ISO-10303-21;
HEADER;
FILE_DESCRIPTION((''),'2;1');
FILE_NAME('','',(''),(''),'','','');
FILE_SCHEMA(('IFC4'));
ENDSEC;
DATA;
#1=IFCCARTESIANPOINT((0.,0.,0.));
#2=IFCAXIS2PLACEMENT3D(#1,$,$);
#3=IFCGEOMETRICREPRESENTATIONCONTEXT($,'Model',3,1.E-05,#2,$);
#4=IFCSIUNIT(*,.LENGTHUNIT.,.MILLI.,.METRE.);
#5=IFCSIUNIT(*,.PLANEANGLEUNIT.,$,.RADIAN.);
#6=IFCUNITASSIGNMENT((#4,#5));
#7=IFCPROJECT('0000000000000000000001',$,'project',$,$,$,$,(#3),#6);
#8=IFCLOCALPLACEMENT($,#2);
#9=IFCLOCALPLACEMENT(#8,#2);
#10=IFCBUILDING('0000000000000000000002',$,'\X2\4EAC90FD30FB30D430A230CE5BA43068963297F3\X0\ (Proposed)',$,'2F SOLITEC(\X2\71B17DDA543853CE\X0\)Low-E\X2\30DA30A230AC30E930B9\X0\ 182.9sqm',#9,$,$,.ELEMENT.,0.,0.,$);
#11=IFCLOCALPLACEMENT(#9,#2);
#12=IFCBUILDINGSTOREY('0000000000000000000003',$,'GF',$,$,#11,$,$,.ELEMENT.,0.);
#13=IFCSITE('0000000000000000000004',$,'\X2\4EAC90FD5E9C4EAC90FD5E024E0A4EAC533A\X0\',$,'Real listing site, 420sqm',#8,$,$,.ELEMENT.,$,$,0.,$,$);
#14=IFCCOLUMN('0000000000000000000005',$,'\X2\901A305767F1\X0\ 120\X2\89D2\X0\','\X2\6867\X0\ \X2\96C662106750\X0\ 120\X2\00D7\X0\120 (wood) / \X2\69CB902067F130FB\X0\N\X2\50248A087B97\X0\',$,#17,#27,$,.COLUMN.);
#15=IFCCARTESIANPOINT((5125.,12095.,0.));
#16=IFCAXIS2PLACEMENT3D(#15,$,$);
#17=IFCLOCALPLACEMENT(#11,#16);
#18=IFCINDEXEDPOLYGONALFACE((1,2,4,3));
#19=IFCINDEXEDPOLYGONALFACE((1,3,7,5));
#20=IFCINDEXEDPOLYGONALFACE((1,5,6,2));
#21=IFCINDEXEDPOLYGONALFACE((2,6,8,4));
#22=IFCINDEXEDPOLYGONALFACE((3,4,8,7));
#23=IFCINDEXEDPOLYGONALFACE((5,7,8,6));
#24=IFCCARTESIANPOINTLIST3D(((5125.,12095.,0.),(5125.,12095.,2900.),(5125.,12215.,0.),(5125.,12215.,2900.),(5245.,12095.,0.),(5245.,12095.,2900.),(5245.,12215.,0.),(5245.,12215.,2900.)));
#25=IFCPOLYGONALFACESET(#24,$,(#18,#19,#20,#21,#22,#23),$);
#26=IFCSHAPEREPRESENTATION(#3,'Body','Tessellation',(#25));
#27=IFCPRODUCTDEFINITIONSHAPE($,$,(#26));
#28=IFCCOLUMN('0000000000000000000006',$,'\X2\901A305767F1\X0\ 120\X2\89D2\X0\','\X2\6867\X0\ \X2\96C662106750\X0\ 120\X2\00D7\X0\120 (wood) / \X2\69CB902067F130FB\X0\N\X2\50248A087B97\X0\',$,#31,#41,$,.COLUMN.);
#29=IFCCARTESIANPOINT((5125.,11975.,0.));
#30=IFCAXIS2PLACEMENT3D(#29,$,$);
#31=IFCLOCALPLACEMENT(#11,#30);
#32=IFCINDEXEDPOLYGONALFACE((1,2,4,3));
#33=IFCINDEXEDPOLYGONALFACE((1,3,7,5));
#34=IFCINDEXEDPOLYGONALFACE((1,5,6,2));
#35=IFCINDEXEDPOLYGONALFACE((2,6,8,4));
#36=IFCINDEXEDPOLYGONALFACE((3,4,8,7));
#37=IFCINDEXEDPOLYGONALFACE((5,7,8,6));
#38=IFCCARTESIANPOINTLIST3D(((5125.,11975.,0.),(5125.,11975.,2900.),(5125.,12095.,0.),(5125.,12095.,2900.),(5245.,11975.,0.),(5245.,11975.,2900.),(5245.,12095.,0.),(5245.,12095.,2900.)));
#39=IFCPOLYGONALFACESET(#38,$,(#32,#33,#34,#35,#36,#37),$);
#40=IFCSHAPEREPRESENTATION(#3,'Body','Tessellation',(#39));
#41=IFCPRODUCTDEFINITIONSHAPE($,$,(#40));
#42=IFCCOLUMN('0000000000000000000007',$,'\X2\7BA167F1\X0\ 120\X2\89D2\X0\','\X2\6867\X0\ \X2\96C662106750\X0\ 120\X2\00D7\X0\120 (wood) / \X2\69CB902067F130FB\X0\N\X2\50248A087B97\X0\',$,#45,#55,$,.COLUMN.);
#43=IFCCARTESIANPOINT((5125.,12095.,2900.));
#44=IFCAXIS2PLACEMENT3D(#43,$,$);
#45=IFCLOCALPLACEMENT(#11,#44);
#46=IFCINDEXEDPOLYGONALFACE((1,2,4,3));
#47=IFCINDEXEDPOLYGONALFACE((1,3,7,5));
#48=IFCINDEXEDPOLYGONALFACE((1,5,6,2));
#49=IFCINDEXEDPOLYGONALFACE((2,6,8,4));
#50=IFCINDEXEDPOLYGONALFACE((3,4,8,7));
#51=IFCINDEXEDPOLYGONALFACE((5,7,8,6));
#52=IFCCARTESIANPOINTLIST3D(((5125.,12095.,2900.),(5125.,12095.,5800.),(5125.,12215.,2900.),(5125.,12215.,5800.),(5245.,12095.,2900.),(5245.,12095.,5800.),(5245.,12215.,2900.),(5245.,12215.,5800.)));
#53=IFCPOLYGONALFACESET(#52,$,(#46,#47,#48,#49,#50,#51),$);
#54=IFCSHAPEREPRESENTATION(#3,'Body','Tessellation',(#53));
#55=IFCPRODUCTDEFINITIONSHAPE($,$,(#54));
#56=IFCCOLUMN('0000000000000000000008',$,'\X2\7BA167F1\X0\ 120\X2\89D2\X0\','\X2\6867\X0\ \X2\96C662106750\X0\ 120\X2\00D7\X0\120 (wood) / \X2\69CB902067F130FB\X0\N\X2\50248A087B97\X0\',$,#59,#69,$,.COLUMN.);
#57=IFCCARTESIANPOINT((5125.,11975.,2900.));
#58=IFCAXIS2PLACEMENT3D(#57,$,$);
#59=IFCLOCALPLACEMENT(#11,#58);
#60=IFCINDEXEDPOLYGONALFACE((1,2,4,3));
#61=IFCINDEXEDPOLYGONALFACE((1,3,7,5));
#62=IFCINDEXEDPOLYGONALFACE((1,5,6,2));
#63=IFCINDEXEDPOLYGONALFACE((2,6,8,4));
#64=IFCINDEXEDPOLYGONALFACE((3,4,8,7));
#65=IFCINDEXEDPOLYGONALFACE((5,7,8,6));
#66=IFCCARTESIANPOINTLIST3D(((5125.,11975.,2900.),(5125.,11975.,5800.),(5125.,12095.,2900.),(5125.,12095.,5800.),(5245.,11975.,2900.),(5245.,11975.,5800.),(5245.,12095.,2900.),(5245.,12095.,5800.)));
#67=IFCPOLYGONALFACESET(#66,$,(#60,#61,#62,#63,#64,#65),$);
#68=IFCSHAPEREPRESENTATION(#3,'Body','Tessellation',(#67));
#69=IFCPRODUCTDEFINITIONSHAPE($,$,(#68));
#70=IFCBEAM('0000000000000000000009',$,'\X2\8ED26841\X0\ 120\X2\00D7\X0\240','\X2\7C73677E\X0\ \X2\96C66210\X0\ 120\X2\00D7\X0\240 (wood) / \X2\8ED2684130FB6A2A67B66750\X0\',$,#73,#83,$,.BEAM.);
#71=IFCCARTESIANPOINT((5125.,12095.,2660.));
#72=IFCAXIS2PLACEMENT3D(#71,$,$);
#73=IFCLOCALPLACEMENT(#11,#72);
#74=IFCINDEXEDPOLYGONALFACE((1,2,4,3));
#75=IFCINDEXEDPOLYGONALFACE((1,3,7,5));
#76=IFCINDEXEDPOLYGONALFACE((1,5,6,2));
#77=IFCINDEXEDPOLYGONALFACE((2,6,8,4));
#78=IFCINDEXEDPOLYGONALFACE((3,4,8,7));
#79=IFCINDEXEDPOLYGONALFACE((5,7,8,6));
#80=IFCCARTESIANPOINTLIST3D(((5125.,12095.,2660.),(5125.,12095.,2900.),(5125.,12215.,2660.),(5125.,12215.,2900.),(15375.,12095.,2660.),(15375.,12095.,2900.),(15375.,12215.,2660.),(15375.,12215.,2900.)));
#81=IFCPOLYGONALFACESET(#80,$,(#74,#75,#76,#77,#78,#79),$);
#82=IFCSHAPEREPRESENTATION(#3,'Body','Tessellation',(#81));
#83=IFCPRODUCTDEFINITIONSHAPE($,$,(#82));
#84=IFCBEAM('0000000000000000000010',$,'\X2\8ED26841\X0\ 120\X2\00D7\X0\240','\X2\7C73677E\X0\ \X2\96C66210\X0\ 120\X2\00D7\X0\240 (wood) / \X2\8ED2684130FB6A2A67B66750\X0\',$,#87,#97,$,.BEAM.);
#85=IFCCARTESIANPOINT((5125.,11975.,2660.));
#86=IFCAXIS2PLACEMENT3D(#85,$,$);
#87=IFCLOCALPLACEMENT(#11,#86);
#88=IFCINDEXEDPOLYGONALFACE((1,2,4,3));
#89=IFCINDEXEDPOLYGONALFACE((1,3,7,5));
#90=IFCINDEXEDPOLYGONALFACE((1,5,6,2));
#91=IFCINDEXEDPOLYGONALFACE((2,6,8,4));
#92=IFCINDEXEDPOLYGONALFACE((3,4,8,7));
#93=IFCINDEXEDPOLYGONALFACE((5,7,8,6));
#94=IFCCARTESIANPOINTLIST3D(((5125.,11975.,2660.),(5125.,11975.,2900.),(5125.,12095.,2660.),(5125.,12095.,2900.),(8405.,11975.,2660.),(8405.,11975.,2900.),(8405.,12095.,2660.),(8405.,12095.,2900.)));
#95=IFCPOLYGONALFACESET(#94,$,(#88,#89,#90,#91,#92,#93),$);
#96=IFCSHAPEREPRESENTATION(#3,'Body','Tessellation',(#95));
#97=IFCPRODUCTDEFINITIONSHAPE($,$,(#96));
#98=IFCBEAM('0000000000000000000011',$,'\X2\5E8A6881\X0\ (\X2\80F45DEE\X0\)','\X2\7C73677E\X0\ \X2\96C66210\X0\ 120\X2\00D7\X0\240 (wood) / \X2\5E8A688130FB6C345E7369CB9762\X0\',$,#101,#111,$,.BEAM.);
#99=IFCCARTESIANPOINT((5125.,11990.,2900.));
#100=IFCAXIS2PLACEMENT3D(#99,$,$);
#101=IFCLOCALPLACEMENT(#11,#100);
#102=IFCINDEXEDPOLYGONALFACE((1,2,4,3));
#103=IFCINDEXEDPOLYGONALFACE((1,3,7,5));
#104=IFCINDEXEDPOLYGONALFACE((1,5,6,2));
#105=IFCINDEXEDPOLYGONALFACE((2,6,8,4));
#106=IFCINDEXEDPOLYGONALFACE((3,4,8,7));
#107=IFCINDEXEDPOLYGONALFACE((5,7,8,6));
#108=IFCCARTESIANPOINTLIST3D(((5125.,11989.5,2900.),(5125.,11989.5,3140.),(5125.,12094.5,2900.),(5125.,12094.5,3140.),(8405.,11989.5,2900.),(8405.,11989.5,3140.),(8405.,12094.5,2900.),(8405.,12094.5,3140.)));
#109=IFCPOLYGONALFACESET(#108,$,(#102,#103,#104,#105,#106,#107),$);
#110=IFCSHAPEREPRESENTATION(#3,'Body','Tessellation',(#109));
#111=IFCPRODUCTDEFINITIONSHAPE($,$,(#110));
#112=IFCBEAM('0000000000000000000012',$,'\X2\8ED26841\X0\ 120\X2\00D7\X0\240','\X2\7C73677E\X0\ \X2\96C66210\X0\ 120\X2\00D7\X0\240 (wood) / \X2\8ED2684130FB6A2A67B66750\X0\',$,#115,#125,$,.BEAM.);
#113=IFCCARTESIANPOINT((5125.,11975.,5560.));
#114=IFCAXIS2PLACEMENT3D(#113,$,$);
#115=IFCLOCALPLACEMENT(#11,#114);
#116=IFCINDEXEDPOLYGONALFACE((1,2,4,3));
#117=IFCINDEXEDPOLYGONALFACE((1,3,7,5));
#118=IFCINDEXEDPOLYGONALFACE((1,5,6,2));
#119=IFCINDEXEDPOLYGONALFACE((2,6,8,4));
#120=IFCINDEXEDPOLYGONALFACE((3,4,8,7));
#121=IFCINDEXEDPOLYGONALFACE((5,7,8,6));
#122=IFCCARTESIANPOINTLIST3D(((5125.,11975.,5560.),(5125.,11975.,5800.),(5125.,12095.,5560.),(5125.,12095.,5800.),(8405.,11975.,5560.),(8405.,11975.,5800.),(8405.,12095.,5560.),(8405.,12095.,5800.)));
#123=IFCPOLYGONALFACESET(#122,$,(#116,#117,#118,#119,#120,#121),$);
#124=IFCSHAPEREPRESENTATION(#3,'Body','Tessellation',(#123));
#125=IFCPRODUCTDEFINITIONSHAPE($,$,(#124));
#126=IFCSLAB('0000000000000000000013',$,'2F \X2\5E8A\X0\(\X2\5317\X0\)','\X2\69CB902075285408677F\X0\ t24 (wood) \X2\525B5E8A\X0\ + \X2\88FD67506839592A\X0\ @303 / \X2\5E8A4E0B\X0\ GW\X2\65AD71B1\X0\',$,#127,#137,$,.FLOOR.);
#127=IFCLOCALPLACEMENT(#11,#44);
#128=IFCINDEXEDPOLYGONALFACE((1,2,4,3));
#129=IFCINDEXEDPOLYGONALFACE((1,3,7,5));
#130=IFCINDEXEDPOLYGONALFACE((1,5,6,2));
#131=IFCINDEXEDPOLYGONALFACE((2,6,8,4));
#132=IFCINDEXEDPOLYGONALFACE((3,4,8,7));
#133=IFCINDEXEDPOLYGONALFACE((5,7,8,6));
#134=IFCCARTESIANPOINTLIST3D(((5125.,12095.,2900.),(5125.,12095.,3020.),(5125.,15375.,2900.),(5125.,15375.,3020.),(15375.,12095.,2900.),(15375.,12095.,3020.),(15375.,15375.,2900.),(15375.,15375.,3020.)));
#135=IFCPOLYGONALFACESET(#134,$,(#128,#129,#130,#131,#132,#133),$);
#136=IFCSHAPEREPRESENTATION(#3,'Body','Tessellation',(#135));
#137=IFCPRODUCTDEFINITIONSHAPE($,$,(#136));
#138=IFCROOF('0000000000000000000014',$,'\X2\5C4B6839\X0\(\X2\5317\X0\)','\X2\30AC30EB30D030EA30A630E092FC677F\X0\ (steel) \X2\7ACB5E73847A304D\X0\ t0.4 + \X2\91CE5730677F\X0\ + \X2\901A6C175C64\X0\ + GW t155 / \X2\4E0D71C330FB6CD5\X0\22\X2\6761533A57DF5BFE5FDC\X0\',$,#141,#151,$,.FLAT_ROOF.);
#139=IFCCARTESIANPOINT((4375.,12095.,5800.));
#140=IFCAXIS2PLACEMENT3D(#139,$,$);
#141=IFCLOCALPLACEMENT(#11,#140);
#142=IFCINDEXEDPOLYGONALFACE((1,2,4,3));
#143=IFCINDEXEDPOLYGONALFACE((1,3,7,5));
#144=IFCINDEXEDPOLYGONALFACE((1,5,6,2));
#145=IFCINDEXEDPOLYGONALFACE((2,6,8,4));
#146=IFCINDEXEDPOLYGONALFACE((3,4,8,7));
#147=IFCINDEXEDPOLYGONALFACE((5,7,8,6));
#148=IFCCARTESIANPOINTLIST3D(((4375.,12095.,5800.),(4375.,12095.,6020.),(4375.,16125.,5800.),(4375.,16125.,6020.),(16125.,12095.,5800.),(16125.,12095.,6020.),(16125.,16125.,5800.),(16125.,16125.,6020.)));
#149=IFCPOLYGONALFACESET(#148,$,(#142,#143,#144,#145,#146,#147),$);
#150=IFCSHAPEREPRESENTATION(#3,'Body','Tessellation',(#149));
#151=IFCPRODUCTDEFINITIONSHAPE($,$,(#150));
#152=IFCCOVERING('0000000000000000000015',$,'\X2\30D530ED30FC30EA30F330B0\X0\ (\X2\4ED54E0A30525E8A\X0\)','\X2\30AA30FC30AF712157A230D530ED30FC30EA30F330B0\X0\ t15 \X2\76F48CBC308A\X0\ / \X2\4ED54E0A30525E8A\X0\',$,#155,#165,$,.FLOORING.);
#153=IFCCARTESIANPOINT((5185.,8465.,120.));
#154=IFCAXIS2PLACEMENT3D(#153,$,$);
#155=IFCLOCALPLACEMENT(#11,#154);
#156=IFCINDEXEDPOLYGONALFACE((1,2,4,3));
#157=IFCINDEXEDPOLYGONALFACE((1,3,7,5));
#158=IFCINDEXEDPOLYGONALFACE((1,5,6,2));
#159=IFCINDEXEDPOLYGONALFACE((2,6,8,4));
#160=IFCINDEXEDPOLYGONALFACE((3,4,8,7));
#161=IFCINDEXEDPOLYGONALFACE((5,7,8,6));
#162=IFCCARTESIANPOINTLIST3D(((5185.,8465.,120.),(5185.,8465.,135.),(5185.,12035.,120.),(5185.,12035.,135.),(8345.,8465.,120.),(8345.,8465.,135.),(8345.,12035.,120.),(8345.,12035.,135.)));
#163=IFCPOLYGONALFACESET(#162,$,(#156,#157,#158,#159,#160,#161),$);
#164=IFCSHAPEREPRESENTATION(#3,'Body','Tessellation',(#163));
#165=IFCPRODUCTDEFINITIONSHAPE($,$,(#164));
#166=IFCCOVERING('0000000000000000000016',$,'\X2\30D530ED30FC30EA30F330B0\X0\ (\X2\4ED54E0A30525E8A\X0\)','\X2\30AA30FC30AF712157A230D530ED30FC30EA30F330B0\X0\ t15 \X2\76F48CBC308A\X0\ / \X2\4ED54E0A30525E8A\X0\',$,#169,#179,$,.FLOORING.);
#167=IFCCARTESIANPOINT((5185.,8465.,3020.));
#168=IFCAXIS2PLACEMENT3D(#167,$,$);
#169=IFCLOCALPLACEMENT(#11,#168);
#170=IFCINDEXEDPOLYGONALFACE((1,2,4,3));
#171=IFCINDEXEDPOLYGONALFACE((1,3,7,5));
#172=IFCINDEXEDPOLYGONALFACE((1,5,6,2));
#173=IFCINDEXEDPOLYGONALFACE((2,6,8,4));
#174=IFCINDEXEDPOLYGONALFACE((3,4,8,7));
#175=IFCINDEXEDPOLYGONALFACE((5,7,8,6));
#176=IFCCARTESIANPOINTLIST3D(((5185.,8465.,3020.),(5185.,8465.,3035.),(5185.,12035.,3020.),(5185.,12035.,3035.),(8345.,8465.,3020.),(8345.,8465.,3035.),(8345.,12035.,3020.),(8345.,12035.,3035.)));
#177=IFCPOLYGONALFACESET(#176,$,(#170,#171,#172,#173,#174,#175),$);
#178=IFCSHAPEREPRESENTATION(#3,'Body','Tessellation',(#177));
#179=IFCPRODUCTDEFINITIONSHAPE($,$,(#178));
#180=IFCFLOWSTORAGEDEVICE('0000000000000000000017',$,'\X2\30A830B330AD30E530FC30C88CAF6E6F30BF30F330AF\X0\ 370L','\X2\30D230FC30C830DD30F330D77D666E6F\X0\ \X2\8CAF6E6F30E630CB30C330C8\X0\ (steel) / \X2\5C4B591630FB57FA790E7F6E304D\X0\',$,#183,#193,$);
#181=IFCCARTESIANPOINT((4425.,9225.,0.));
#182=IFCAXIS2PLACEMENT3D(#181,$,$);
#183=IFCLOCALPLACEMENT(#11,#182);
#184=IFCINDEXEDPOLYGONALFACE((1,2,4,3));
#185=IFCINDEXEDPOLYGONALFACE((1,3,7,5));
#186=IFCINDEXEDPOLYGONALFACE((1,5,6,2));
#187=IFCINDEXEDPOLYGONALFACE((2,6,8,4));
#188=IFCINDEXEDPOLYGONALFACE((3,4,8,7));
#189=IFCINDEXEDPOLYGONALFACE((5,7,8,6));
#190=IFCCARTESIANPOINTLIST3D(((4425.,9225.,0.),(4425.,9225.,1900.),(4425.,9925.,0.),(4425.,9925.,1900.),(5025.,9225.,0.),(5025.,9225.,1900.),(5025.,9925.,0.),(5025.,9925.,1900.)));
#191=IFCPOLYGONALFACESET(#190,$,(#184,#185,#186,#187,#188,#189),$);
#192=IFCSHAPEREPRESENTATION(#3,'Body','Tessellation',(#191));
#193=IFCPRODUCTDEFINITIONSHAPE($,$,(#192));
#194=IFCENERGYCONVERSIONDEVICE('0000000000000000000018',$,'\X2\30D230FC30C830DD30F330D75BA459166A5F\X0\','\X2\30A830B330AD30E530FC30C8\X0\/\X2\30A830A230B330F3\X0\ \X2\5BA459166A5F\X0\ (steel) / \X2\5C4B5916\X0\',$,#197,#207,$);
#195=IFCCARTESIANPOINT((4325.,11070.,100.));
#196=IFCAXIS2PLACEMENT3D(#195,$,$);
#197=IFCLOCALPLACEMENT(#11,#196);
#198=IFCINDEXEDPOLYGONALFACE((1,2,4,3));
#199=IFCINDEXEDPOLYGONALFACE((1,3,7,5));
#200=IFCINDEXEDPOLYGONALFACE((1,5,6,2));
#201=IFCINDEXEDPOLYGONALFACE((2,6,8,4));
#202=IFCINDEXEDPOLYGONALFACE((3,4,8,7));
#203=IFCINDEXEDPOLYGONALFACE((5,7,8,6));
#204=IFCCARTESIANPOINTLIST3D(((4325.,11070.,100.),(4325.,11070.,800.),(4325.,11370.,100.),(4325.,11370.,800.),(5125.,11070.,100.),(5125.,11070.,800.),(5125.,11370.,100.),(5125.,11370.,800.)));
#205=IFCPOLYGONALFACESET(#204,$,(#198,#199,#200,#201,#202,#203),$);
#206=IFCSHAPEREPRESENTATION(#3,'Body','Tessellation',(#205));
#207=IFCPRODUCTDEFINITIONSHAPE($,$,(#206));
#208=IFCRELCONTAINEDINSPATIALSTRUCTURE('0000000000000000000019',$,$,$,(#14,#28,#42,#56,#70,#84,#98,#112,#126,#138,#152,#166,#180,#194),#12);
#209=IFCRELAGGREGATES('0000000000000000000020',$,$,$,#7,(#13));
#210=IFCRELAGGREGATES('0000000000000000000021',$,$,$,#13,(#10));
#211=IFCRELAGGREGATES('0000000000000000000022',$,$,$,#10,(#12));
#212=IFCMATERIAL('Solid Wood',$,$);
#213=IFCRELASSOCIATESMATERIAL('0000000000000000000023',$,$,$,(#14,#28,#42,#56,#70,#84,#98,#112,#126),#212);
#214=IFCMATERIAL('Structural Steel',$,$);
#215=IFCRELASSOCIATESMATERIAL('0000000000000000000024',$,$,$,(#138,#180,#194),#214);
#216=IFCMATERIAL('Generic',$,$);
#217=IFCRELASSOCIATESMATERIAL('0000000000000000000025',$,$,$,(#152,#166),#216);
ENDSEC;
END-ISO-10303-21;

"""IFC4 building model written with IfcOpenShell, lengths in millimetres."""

from ifc_helpers import new_model, si_unit, frame, frame_2d, origin, place, context, project, spatial, rectangle, extrude, material, element, save


model = new_model("IFC4")

# Units and contexts
model_context = context("Model", 3, precision=1e-05, world=origin())
ifc_project = project(units=[si_unit("LENGTHUNIT", "METRE", prefix="MILLI"), si_unit("PLANEANGLEUNIT", "RADIAN")], contexts=[model_context])

# Site, building, storey
site_placement = place(None, origin())
site = spatial("IfcSite", under=ifc_project, at=site_placement, Name="京都府京都市上京区", ObjectType="Real listing site, 420sqm", CompositionType="ELEMENT", RefElevation=0.0)
building_placement = place(site_placement, origin())
building = spatial("IfcBuilding", under=site, at=building_placement, Name="京都・ピアノ室と防音 (Proposed)", ObjectType="2F SOLITEC(熱線吸収)Low-Eペアガラス 182.9sqm", CompositionType="ELEMENT", ElevationOfRefHeight=0.0, ElevationOfTerrain=0.0)
storey_placement = place(building_placement, origin())
storey = spatial("IfcBuildingStorey", under=building, at=storey_placement, Name="GF", CompositionType="ELEMENT", Elevation=0.0)

# Columns
ifc_material_1 = material(Name="Solid Wood")
column_1_placement = place(storey_placement, frame((5125.0, 12095.0, 0.0)))
element("IfcColumn", 1, at=column_1_placement, inside=storey, material=ifc_material_1, Name="通し柱 120角", Description="桧 集成材 120×120 (wood) / 構造柱・N値計算", PredefinedType="COLUMN", context=model_context, shape_type="SweptSolid", body=[
    extrude(rectangle(XDim=120.0, YDim=120.0, at=frame_2d((60.0, 60.0))), frame((5125.0, 12095.0, 0.0)), (0.0, 0.0, 1.0), 2900.0),
])
column_2_placement = place(storey_placement, frame((5125.0, 11975.0, 0.0)))
element("IfcColumn", 2, at=column_2_placement, inside=storey, material=ifc_material_1, Name="通し柱 120角", Description="桧 集成材 120×120 (wood) / 構造柱・N値計算", PredefinedType="COLUMN", context=model_context, shape_type="SweptSolid", body=[
    extrude(rectangle(XDim=120.0, YDim=120.0, at=frame_2d((60.0, 60.0))), frame((5125.0, 11975.0, 0.0)), (0.0, 0.0, 1.0), 2900.0),
])
column_3_placement = place(storey_placement, frame((5125.0, 12095.0, 2900.0)))
element("IfcColumn", 3, at=column_3_placement, inside=storey, material=ifc_material_1, Name="管柱 120角", Description="桧 集成材 120×120 (wood) / 構造柱・N値計算", PredefinedType="COLUMN", context=model_context, shape_type="SweptSolid", body=[
    extrude(rectangle(XDim=120.0, YDim=120.0, at=frame_2d((60.0, 60.0))), frame((5125.0, 12095.0, 2900.0)), (0.0, 0.0, 1.0), 2900.0),
])
column_4_placement = place(storey_placement, frame((5125.0, 11975.0, 2900.0)))
element("IfcColumn", 4, at=column_4_placement, inside=storey, material=ifc_material_1, Name="管柱 120角", Description="桧 集成材 120×120 (wood) / 構造柱・N値計算", PredefinedType="COLUMN", context=model_context, shape_type="SweptSolid", body=[
    extrude(rectangle(XDim=120.0, YDim=120.0, at=frame_2d((60.0, 60.0))), frame((5125.0, 11975.0, 2900.0)), (0.0, 0.0, 1.0), 2900.0),
])

# Beams
beam_1_placement = place(storey_placement, frame((5125.0, 12095.0, 2660.0)))
element("IfcBeam", 5, at=beam_1_placement, inside=storey, material=ifc_material_1, Name="軒桁 120×240", Description="米松 集成 120×240 (wood) / 軒桁・横架材", PredefinedType="BEAM", context=model_context, shape_type="SweptSolid", body=[
    extrude(rectangle(XDim=10250.0, YDim=120.0, at=frame_2d((5125.0, 60.0))), frame((5125.0, 12095.0, 2660.0)), (0.0, 0.0, 1.0), 240.0),
])
beam_2_placement = place(storey_placement, frame((5125.0, 11975.0, 2660.0)))
element("IfcBeam", 6, at=beam_2_placement, inside=storey, material=ifc_material_1, Name="軒桁 120×240", Description="米松 集成 120×240 (wood) / 軒桁・横架材", PredefinedType="BEAM", context=model_context, shape_type="SweptSolid", body=[
    extrude(rectangle(XDim=3280.0, YDim=120.0, at=frame_2d((1640.0, 60.0))), frame((5125.0, 11975.0, 2660.0)), (0.0, 0.0, 1.0), 240.0),
])
beam_3_placement = place(storey_placement, frame((5125.0, 11990.0, 2900.0)))
element("IfcBeam", 7, at=beam_3_placement, inside=storey, material=ifc_material_1, Name="床梁 (胴差)", Description="米松 集成 120×240 (wood) / 床梁・水平構面", PredefinedType="BEAM", context=model_context, shape_type="SweptSolid", body=[
    extrude(rectangle(XDim=3280.0, YDim=105.0, at=frame_2d((1640.0, 52.0))), frame((5125.0, 11990.0, 2900.0)), (0.0, 0.0, 1.0), 240.0),
])
beam_4_placement = place(storey_placement, frame((5125.0, 11975.0, 5560.0)))
element("IfcBeam", 8, at=beam_4_placement, inside=storey, material=ifc_material_1, Name="軒桁 120×240", Description="米松 集成 120×240 (wood) / 軒桁・横架材", PredefinedType="BEAM", context=model_context, shape_type="SweptSolid", body=[
    extrude(rectangle(XDim=3280.0, YDim=120.0, at=frame_2d((1640.0, 60.0))), frame((5125.0, 11975.0, 5560.0)), (0.0, 0.0, 1.0), 240.0),
])

# Slab
slab_1_placement = place(storey_placement, frame((5125.0, 12095.0, 2900.0)))
element("IfcSlab", 9, at=slab_1_placement, inside=storey, material=ifc_material_1, Name="2F 床(北)", Description="構造用合板 t24 (wood) 剛床 + 製材根太 @303 / 床下 GW断熱", PredefinedType="FLOOR", context=model_context, shape_type="SweptSolid", body=[
    extrude(rectangle(XDim=10250.0, YDim=3280.0, at=frame_2d((5125.0, 1640.0))), frame((5125.0, 12095.0, 2900.0)), (0.0, 0.0, 1.0), 120.0),
])

# Roof
ifc_material_2 = material(Name="Structural Steel")
for number, where, name in (
    (10, (4375.0, 12095.0, 5800.0), "屋根(北)"),
):
    element("IfcRoof", number, at=place(storey_placement, frame(where)), inside=storey, material=ifc_material_2, Name=name, Description="ガルバリウム鋼板 (steel) 立平葺き t0.4 + 野地板 + 通気層 + GW t155 / 不燃・法22条区域対応", PredefinedType="FLAT_ROOF", context=model_context, shape_type="SweptSolid", body=[
        extrude(rectangle(XDim=11750.0, YDim=4030.0, at=frame_2d((5875.0, 2015.0))), frame((4375.0, 12095.0, 5800.0)), (0.0, 0.0, 1.0), 220.0),
    ])

# Coverings
ifc_material_3 = material(Name="Generic")
covering_1_placement = place(storey_placement, frame((5185.0, 8465.0, 120.0)))
element("IfcCovering", 11, at=covering_1_placement, inside=storey, material=ifc_material_3, Name="フローリング (仕上げ床)", Description="オーク無垢フローリング t15 直貼り / 仕上げ床", PredefinedType="FLOORING", context=model_context, shape_type="SweptSolid", body=[
    extrude(rectangle(XDim=3160.0, YDim=3570.0, at=frame_2d((1580.0, 1785.0))), frame((5185.0, 8465.0, 120.0)), (0.0, 0.0, 1.0), 15.0),
])
covering_2_placement = place(storey_placement, frame((5185.0, 8465.0, 3020.0)))
element("IfcCovering", 12, at=covering_2_placement, inside=storey, material=ifc_material_3, Name="フローリング (仕上げ床)", Description="オーク無垢フローリング t15 直貼り / 仕上げ床", PredefinedType="FLOORING", context=model_context, shape_type="SweptSolid", body=[
    extrude(rectangle(XDim=3160.0, YDim=3570.0, at=frame_2d((1580.0, 1785.0))), frame((5185.0, 8465.0, 3020.0)), (0.0, 0.0, 1.0), 15.0),
])

# Flow storage device
flow_storage_device_placement = place(storey_placement, frame((4425.0, 9225.0, 0.0)))
element("IfcFlowStorageDevice", 13, at=flow_storage_device_placement, inside=storey, material=ifc_material_2, Name="エコキュート貯湯タンク 370L", Description="ヒートポンプ給湯 貯湯ユニット (steel) / 屋外・基礎置き", context=model_context, shape_type="SweptSolid", body=[
    extrude(rectangle(XDim=600.0, YDim=700.0, at=frame_2d((300.0, 350.0))), frame((4425.0, 9225.0, 0.0)), (0.0, 0.0, 1.0), 1900.0),
])

# Energy conversion device
energy_conversion_device_placement = place(storey_placement, frame((4325.0, 11070.0, 100.0)))
element("IfcEnergyConversionDevice", 14, at=energy_conversion_device_placement, inside=storey, material=ifc_material_2, Name="ヒートポンプ室外機", Description="エコキュート/エアコン 室外機 (steel) / 屋外", context=model_context, shape_type="SweptSolid", body=[
    extrude(rectangle(XDim=800.0, YDim=300.0, at=frame_2d((400.0, 150.0))), frame((4325.0, 11070.0, 100.0)), (0.0, 0.0, 1.0), 700.0),
])

save(model, "model.ifc")
